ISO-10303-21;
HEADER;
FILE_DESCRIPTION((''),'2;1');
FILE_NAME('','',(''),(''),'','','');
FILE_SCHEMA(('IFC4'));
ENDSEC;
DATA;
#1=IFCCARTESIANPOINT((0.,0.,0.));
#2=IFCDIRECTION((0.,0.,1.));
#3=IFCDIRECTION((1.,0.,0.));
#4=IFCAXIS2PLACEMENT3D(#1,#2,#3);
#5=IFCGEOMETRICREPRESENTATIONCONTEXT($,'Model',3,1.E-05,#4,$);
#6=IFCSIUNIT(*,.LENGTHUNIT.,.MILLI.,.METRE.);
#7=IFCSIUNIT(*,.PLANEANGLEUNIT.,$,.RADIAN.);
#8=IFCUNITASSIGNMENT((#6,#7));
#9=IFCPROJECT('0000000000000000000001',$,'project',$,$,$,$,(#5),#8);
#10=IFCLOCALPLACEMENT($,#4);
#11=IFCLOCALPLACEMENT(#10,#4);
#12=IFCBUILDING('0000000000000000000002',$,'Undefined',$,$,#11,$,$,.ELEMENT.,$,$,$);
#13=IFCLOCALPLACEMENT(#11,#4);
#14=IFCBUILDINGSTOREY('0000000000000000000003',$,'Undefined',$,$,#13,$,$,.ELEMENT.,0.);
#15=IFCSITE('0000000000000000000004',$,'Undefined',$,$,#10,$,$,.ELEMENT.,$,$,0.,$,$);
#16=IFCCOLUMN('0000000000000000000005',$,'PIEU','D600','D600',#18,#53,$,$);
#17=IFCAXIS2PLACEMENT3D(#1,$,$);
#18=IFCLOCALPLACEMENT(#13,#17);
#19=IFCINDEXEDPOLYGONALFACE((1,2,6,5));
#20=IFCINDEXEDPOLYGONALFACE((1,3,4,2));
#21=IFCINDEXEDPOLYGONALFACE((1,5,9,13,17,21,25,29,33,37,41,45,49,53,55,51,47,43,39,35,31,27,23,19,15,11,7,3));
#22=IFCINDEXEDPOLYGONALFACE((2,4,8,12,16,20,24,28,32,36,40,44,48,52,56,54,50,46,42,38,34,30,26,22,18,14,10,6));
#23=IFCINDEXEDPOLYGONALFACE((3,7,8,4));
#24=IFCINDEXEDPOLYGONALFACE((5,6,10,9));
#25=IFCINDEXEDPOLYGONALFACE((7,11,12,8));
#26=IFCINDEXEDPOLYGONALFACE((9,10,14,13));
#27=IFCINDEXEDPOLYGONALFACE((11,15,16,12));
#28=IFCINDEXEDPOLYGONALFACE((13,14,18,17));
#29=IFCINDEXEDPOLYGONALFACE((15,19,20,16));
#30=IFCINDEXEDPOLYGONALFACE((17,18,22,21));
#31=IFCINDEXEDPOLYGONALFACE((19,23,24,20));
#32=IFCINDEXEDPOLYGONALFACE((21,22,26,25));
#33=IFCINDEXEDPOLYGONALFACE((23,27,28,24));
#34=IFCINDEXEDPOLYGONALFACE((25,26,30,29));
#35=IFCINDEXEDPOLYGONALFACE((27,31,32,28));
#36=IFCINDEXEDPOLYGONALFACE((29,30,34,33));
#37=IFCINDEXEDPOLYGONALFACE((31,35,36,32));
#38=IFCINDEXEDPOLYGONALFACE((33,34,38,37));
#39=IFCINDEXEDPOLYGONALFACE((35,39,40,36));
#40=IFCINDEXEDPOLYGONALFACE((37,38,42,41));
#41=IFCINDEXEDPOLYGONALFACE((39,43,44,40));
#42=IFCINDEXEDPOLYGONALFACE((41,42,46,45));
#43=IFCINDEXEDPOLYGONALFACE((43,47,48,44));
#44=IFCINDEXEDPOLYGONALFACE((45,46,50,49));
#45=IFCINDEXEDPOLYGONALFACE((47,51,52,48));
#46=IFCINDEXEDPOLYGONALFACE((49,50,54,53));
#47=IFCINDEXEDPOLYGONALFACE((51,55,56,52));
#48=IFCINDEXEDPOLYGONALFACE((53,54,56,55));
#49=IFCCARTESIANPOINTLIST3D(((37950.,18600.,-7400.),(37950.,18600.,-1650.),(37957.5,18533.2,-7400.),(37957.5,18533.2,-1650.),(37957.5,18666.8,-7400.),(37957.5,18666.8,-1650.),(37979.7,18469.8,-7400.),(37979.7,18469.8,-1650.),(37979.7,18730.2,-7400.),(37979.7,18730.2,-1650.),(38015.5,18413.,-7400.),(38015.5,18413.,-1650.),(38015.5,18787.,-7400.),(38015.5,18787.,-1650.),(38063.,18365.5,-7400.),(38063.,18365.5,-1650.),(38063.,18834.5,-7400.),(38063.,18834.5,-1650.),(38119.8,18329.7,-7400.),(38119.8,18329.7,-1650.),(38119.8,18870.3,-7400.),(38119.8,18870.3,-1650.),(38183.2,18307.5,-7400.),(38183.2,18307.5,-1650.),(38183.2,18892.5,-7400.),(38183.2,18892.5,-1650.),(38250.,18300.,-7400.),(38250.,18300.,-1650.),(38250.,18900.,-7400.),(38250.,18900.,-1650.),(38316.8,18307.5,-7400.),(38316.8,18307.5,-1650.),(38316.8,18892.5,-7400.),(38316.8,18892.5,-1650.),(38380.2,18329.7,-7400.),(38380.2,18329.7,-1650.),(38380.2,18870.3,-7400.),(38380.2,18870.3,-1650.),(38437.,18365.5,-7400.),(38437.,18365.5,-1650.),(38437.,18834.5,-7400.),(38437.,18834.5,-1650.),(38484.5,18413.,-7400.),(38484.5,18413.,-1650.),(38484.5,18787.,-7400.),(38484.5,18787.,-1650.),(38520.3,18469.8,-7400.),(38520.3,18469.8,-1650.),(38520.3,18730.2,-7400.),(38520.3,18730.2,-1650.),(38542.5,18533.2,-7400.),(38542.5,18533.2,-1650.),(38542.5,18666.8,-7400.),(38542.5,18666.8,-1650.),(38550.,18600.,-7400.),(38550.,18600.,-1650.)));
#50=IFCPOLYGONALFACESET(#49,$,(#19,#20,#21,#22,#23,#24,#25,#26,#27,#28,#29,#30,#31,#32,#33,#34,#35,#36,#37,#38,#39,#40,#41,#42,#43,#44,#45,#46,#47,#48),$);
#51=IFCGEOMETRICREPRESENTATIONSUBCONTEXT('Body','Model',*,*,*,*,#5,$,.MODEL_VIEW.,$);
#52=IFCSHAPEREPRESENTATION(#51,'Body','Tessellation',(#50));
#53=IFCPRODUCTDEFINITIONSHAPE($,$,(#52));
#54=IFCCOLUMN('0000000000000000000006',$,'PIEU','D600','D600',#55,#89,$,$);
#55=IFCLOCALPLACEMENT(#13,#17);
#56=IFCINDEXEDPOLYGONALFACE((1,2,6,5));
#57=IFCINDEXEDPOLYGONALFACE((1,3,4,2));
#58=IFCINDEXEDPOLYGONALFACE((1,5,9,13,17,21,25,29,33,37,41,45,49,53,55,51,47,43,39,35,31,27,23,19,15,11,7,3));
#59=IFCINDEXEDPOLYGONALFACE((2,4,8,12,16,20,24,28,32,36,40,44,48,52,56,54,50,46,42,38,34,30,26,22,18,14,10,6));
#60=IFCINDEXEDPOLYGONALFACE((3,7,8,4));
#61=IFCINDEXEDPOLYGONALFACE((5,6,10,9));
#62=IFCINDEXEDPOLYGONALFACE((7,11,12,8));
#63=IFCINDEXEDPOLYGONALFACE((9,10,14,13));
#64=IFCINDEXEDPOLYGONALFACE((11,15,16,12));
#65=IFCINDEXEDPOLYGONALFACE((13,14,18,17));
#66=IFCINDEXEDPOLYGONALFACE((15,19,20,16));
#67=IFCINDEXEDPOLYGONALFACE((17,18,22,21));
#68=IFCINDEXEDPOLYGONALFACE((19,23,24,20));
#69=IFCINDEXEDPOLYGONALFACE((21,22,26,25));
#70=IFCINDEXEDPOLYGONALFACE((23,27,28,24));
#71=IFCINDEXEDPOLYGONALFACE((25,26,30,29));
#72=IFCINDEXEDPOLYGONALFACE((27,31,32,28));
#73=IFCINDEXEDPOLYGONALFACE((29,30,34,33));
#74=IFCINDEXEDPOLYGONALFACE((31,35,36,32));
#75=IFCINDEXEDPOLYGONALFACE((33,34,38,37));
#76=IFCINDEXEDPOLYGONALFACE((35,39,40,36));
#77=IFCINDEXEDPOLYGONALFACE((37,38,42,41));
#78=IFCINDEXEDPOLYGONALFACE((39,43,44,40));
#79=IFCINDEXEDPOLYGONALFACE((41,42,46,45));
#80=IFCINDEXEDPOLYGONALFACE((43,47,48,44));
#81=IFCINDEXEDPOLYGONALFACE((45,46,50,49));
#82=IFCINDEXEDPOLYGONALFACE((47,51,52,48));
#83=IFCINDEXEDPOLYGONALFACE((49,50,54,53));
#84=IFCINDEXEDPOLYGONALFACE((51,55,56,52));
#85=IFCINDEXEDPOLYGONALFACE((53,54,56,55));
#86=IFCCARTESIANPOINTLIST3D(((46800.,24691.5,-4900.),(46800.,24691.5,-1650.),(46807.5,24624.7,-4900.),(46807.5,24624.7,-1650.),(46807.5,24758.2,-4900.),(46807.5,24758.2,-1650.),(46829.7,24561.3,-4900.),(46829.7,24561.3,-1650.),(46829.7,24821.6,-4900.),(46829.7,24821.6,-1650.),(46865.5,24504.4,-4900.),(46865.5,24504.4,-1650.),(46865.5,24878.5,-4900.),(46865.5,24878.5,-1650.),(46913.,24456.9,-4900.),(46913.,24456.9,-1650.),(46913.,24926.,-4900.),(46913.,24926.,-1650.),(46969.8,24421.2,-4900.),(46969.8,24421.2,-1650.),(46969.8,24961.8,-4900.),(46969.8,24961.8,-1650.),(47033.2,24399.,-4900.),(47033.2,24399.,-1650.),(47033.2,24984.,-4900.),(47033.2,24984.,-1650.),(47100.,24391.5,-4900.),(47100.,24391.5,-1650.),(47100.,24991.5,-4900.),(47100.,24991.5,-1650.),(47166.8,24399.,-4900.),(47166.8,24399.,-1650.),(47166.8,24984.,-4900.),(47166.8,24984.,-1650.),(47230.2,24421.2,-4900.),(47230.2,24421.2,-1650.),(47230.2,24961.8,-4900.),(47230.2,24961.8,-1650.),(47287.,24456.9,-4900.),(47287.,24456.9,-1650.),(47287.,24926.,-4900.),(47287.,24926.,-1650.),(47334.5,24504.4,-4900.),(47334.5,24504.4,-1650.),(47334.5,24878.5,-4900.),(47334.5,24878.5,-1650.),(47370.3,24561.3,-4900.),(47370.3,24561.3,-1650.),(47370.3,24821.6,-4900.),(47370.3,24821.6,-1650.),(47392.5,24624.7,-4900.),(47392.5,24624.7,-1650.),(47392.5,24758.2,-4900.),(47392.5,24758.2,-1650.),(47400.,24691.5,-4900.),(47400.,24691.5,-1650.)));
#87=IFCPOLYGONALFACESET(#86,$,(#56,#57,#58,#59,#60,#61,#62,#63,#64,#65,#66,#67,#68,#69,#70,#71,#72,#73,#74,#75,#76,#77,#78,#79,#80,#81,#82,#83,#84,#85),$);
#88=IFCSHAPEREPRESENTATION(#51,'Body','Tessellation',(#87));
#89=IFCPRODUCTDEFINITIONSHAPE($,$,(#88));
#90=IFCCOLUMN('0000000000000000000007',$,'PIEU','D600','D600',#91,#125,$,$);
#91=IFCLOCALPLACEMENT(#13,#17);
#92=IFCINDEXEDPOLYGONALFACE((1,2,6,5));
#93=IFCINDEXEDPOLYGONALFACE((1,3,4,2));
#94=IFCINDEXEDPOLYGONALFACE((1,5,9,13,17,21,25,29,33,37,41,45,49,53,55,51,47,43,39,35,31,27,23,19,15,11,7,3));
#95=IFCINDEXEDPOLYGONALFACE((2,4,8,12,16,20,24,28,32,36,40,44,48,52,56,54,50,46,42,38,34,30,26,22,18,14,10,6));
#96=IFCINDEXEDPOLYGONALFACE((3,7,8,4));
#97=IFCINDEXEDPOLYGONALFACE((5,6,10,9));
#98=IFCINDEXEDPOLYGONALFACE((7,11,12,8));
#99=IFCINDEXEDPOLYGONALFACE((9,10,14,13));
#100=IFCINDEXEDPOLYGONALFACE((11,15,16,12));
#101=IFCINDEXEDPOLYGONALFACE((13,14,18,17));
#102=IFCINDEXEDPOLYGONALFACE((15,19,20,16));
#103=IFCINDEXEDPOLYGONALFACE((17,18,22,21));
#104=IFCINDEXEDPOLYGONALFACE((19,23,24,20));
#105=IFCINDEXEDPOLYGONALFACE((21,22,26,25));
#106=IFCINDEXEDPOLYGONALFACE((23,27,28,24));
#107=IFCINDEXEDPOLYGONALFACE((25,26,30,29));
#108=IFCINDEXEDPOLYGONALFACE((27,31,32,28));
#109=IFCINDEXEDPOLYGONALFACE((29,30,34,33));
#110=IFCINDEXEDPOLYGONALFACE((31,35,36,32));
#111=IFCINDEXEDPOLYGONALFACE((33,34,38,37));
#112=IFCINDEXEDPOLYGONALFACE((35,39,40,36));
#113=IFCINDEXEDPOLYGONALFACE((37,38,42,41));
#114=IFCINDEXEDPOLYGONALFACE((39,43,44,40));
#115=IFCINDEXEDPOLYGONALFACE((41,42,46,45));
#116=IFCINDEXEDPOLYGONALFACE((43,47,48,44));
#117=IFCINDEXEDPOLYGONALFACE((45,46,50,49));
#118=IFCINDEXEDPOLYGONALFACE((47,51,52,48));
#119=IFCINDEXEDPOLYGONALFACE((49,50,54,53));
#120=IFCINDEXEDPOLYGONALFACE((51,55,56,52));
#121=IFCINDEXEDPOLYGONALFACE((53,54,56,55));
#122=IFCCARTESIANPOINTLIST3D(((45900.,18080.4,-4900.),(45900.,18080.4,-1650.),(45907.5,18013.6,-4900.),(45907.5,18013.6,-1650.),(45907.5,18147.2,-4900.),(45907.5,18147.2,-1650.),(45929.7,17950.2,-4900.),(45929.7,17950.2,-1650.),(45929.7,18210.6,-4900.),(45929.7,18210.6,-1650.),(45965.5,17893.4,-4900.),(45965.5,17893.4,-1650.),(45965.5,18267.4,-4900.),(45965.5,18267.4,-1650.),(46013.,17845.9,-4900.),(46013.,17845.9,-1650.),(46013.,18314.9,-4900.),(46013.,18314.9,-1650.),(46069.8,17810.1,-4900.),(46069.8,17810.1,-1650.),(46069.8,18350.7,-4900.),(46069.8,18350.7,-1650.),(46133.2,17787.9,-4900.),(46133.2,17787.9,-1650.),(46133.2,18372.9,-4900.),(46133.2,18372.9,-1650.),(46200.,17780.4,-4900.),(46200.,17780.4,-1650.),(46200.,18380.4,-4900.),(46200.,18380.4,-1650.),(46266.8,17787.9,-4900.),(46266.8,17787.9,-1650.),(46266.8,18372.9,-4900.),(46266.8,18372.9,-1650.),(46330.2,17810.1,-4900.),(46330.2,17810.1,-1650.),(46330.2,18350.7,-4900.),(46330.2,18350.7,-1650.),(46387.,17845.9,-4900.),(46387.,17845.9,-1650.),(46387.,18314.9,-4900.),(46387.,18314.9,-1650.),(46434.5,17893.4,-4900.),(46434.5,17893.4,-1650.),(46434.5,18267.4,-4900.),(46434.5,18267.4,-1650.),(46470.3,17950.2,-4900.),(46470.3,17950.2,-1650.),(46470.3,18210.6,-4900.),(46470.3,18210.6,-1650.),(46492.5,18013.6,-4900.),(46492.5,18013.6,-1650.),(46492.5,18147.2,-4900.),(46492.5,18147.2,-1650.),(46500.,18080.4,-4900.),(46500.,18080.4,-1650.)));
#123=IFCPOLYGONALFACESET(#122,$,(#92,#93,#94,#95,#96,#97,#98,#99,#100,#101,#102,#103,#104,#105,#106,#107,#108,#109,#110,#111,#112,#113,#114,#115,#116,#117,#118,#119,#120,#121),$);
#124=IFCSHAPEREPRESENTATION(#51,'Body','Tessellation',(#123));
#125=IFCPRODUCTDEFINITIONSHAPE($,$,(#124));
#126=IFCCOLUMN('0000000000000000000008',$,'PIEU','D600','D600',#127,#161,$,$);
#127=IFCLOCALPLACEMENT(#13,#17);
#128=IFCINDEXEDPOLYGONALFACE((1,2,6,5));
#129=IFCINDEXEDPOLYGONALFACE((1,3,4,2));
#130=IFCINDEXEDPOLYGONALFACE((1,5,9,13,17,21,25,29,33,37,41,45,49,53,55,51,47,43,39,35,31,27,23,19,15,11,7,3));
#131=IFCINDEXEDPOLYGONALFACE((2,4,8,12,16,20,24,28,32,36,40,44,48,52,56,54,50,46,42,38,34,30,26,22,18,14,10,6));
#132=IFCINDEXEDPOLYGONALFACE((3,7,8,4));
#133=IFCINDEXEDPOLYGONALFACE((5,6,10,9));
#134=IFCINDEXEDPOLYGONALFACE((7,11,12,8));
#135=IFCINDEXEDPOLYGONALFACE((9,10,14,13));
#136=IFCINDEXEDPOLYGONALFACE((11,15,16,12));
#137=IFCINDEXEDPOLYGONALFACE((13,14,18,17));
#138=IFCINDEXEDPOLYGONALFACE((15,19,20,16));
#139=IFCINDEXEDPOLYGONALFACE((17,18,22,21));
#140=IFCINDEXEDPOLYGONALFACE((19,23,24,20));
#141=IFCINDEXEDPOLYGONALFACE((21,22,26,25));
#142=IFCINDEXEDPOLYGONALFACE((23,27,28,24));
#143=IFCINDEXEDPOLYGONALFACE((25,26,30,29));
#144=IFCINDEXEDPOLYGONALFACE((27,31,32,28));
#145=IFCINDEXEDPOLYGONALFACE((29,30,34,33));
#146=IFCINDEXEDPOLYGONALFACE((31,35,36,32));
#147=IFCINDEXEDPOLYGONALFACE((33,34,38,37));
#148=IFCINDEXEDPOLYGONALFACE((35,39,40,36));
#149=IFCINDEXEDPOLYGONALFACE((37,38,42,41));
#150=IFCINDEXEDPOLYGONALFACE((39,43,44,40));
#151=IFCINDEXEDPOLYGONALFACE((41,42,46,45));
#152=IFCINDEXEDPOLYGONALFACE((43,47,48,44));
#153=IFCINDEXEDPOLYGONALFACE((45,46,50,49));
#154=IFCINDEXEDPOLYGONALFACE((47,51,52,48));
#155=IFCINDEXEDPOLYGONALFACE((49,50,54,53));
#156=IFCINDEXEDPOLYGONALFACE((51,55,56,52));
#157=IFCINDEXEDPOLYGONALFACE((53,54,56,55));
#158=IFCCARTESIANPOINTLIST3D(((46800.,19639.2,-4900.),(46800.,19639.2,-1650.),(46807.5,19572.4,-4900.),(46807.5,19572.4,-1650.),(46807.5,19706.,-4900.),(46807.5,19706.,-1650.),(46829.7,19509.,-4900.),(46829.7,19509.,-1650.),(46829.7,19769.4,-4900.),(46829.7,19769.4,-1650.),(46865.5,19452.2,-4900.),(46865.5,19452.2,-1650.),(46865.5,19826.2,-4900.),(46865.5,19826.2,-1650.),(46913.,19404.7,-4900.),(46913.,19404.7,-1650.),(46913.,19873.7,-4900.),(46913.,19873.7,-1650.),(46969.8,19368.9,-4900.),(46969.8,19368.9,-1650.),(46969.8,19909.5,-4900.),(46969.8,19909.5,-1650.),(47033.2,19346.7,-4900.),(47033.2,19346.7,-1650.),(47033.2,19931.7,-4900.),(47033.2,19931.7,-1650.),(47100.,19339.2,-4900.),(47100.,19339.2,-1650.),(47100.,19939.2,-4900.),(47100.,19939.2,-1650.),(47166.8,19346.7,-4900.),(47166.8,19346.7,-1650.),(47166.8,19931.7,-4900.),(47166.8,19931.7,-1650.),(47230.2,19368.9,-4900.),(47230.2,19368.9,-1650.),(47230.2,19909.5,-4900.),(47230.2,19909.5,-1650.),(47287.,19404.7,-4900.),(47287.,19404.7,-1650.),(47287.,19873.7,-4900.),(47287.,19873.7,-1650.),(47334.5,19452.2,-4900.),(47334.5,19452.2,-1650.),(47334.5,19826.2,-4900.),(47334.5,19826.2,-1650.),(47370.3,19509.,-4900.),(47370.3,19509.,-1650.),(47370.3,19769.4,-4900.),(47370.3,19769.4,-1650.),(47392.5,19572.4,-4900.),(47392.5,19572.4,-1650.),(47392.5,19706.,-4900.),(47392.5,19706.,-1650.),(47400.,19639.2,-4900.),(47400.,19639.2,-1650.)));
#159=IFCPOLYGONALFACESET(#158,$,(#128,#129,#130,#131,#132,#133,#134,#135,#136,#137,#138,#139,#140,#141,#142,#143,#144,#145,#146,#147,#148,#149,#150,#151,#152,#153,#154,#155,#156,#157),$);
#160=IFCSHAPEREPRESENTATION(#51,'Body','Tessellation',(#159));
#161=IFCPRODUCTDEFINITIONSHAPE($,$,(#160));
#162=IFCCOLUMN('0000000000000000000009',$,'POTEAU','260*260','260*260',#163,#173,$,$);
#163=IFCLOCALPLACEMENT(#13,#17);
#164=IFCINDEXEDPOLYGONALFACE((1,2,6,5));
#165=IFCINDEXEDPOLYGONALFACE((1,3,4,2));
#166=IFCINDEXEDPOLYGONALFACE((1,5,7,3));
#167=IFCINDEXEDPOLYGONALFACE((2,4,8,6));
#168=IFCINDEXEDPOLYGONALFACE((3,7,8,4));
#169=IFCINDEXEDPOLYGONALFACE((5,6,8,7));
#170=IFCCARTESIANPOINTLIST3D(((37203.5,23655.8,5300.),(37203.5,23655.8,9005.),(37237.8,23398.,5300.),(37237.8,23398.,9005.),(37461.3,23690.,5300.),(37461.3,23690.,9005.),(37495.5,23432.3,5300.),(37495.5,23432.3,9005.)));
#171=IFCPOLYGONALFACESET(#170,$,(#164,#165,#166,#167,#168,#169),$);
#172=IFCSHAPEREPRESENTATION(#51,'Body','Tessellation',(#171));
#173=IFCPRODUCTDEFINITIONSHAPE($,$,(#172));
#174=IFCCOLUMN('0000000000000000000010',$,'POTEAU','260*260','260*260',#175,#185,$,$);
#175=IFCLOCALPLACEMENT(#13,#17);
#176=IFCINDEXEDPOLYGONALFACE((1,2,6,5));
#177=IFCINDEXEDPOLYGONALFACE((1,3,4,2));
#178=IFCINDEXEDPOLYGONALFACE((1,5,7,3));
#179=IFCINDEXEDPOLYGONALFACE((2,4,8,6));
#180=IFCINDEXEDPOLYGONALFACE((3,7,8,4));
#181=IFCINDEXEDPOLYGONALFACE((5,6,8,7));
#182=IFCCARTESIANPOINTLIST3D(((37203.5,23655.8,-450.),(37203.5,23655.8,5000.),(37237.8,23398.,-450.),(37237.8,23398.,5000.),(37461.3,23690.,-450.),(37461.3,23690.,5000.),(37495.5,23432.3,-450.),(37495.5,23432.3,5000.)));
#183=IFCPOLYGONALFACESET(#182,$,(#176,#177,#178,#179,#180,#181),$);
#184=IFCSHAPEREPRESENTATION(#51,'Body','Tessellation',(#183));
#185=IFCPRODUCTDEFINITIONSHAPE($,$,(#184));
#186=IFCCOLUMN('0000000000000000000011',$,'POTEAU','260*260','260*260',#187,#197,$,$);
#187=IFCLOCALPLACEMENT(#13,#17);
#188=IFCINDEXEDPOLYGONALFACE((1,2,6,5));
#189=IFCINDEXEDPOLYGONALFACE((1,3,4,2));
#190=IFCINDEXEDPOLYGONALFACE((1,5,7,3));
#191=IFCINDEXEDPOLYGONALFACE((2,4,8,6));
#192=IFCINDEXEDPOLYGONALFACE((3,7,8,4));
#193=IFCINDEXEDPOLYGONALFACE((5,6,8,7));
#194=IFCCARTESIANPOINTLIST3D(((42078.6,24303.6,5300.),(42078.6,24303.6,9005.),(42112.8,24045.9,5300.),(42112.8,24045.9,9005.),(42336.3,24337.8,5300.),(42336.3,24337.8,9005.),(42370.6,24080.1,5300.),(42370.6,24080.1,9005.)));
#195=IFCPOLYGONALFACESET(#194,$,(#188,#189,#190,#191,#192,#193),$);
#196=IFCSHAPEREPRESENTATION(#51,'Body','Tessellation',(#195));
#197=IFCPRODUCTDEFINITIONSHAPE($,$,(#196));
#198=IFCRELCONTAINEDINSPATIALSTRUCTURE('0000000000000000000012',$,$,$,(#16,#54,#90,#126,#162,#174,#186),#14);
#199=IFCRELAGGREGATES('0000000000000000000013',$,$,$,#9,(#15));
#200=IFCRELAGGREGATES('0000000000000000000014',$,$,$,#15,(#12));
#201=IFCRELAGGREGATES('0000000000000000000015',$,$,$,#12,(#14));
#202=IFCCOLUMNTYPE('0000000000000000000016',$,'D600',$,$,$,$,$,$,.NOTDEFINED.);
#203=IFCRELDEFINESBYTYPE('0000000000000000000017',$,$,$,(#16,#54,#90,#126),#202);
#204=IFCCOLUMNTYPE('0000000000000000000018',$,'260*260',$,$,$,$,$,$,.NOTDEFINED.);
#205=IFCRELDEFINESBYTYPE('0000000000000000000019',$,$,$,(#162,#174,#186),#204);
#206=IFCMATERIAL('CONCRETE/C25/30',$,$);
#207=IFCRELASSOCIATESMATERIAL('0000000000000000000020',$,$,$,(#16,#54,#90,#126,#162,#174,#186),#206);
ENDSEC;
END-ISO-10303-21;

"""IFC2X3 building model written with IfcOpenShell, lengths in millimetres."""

from ifc_helpers import new_model, si_unit, frame, origin_with_axes, origin_2d_with_axis, place, context, subcontext, project, spatial, rectangle, circle, extrude, material, type_object, element, save


model = new_model("IFC2X3")

# Units and contexts
model_context = context("Model", 3, precision=1e-05, world=origin_with_axes())
body_context = subcontext(model_context, "Body", "Model", "MODEL_VIEW")
ifc_project = project(units=[si_unit("LENGTHUNIT", "METRE", prefix="MILLI"), si_unit("PLANEANGLEUNIT", "RADIAN")], contexts=[model_context])

# Site, building, storey
site_placement = place(None, origin_with_axes())
site = spatial("IfcSite", under=ifc_project, at=site_placement, Name="Undefined", CompositionType="ELEMENT", RefElevation=0.0)
building_placement = place(site_placement, origin_with_axes())
building = spatial("IfcBuilding", under=site, at=building_placement, Name="Undefined", CompositionType="ELEMENT")
storey_placement = place(building_placement, origin_with_axes())
storey = spatial("IfcBuildingStorey", under=building, at=storey_placement, Name="Undefined", CompositionType="ELEMENT", Elevation=0.0)

# Columns
ifc_material_1 = material(Name="CONCRETE/C25/30")
column_type_1 = type_object("IfcColumnType", Name="D600", PredefinedType="NOTDEFINED")
for number, where, z_axis, x_axis, name in (
    (1, (38250.0, 18600.0, -7400.0), (0.0, 0.0, 1.0), (1.0, 0.0, 0.0), "PIEU"),
):
    element("IfcColumn", number, at=place(storey_placement, frame(where, z_axis=z_axis, x_axis=x_axis)), inside=storey, type_object=column_type_1, material=ifc_material_1, Name=name, Description="D600", ObjectType="D600", context=body_context, shape_type="SweptSolid", body=[
        extrude(circle(Radius=300.0, at=origin_2d_with_axis()), frame((0.0, 0.0, 5750.0), z_axis=(0.0, 0.0, -1.0), x_axis=(0.0, 1.0, 0.0)), (0.0, 0.0, 1.0), 5750.0),
    ])
for number, where, z_axis, x_axis, name in (
    (2, (47100.0, 24691.5, -4900.0), (0.0, 0.0, 1.0), (1.0, 0.0, 0.0), "PIEU"),
    (3, (46200.0, 18080.4, -4900.0), (0.0, 0.0, 1.0), (1.0, 0.0, 0.0), "PIEU"),
    (4, (47100.0, 19639.2, -4900.0), (0.0, 0.0, 1.0), (1.0, 0.0, 0.0), "PIEU"),
):
    element("IfcColumn", number, at=place(storey_placement, frame(where, z_axis=z_axis, x_axis=x_axis)), inside=storey, type_object=column_type_1, material=ifc_material_1, Name=name, Description="D600", ObjectType="D600", context=body_context, shape_type="SweptSolid", body=[
        extrude(circle(Radius=300.0, at=origin_2d_with_axis()), frame((0.0, 0.0, 3250.0), z_axis=(0.0, 0.0, -1.0), x_axis=(-1.0, 0.0, 0.0)), (0.0, 0.0, 1.0), 3250.0),
    ])
column_type_2 = type_object("IfcColumnType", Name="260*260", PredefinedType="NOTDEFINED")
column_1_placement = place(storey_placement, frame((37349.5, 23544.0, 5300.0), z_axis=(0.0, 0.0, 1.0), x_axis=(1.0, 0.0, 0.0)))
element("IfcColumn", 5, at=column_1_placement, inside=storey, type_object=column_type_2, material=ifc_material_1, Name="POTEAU", Description="260*260", ObjectType="260*260", context=body_context, shape_type="SweptSolid", body=[
    extrude(rectangle(XDim=260.0, YDim=260.0, at=origin_2d_with_axis()), frame((0.0, 0.0, 3705.0), z_axis=(0.0, 0.0, -1.0), x_axis=(-0.131727, 0.991286, 0.0)), (0.0, 0.0, 1.0), 3705.0),
])
column_2_placement = place(storey_placement, frame((37349.5, 23544.0, -450.0), z_axis=(0.0, 0.0, 1.0), x_axis=(1.0, 0.0, 0.0)))
element("IfcColumn", 6, at=column_2_placement, inside=storey, type_object=column_type_2, material=ifc_material_1, Name="POTEAU", Description="260*260", ObjectType="260*260", context=body_context, shape_type="SweptSolid", body=[
    extrude(rectangle(XDim=260.0, YDim=260.0, at=origin_2d_with_axis()), frame((0.0, 0.0, 5450.0), z_axis=(0.0, 0.0, -1.0), x_axis=(-0.131727, 0.991286, 0.0)), (0.0, 0.0, 1.0), 5450.0),
])
column_3_placement = place(storey_placement, frame((42224.6, 24191.9, 5300.0), z_axis=(0.0, 0.0, 1.0), x_axis=(1.0, 0.0, 0.0)))
element("IfcColumn", 7, at=column_3_placement, inside=storey, type_object=column_type_2, material=ifc_material_1, Name="POTEAU", Description="260*260", ObjectType="260*260", context=body_context, shape_type="SweptSolid", body=[
    extrude(rectangle(XDim=260.0, YDim=260.0, at=origin_2d_with_axis()), frame((0.0, 0.0, 3705.0), z_axis=(0.0, 0.0, -1.0), x_axis=(-0.131727, 0.991286, 0.0)), (0.0, 0.0, 1.0), 3705.0),
])

save(model, "model.ifc")
